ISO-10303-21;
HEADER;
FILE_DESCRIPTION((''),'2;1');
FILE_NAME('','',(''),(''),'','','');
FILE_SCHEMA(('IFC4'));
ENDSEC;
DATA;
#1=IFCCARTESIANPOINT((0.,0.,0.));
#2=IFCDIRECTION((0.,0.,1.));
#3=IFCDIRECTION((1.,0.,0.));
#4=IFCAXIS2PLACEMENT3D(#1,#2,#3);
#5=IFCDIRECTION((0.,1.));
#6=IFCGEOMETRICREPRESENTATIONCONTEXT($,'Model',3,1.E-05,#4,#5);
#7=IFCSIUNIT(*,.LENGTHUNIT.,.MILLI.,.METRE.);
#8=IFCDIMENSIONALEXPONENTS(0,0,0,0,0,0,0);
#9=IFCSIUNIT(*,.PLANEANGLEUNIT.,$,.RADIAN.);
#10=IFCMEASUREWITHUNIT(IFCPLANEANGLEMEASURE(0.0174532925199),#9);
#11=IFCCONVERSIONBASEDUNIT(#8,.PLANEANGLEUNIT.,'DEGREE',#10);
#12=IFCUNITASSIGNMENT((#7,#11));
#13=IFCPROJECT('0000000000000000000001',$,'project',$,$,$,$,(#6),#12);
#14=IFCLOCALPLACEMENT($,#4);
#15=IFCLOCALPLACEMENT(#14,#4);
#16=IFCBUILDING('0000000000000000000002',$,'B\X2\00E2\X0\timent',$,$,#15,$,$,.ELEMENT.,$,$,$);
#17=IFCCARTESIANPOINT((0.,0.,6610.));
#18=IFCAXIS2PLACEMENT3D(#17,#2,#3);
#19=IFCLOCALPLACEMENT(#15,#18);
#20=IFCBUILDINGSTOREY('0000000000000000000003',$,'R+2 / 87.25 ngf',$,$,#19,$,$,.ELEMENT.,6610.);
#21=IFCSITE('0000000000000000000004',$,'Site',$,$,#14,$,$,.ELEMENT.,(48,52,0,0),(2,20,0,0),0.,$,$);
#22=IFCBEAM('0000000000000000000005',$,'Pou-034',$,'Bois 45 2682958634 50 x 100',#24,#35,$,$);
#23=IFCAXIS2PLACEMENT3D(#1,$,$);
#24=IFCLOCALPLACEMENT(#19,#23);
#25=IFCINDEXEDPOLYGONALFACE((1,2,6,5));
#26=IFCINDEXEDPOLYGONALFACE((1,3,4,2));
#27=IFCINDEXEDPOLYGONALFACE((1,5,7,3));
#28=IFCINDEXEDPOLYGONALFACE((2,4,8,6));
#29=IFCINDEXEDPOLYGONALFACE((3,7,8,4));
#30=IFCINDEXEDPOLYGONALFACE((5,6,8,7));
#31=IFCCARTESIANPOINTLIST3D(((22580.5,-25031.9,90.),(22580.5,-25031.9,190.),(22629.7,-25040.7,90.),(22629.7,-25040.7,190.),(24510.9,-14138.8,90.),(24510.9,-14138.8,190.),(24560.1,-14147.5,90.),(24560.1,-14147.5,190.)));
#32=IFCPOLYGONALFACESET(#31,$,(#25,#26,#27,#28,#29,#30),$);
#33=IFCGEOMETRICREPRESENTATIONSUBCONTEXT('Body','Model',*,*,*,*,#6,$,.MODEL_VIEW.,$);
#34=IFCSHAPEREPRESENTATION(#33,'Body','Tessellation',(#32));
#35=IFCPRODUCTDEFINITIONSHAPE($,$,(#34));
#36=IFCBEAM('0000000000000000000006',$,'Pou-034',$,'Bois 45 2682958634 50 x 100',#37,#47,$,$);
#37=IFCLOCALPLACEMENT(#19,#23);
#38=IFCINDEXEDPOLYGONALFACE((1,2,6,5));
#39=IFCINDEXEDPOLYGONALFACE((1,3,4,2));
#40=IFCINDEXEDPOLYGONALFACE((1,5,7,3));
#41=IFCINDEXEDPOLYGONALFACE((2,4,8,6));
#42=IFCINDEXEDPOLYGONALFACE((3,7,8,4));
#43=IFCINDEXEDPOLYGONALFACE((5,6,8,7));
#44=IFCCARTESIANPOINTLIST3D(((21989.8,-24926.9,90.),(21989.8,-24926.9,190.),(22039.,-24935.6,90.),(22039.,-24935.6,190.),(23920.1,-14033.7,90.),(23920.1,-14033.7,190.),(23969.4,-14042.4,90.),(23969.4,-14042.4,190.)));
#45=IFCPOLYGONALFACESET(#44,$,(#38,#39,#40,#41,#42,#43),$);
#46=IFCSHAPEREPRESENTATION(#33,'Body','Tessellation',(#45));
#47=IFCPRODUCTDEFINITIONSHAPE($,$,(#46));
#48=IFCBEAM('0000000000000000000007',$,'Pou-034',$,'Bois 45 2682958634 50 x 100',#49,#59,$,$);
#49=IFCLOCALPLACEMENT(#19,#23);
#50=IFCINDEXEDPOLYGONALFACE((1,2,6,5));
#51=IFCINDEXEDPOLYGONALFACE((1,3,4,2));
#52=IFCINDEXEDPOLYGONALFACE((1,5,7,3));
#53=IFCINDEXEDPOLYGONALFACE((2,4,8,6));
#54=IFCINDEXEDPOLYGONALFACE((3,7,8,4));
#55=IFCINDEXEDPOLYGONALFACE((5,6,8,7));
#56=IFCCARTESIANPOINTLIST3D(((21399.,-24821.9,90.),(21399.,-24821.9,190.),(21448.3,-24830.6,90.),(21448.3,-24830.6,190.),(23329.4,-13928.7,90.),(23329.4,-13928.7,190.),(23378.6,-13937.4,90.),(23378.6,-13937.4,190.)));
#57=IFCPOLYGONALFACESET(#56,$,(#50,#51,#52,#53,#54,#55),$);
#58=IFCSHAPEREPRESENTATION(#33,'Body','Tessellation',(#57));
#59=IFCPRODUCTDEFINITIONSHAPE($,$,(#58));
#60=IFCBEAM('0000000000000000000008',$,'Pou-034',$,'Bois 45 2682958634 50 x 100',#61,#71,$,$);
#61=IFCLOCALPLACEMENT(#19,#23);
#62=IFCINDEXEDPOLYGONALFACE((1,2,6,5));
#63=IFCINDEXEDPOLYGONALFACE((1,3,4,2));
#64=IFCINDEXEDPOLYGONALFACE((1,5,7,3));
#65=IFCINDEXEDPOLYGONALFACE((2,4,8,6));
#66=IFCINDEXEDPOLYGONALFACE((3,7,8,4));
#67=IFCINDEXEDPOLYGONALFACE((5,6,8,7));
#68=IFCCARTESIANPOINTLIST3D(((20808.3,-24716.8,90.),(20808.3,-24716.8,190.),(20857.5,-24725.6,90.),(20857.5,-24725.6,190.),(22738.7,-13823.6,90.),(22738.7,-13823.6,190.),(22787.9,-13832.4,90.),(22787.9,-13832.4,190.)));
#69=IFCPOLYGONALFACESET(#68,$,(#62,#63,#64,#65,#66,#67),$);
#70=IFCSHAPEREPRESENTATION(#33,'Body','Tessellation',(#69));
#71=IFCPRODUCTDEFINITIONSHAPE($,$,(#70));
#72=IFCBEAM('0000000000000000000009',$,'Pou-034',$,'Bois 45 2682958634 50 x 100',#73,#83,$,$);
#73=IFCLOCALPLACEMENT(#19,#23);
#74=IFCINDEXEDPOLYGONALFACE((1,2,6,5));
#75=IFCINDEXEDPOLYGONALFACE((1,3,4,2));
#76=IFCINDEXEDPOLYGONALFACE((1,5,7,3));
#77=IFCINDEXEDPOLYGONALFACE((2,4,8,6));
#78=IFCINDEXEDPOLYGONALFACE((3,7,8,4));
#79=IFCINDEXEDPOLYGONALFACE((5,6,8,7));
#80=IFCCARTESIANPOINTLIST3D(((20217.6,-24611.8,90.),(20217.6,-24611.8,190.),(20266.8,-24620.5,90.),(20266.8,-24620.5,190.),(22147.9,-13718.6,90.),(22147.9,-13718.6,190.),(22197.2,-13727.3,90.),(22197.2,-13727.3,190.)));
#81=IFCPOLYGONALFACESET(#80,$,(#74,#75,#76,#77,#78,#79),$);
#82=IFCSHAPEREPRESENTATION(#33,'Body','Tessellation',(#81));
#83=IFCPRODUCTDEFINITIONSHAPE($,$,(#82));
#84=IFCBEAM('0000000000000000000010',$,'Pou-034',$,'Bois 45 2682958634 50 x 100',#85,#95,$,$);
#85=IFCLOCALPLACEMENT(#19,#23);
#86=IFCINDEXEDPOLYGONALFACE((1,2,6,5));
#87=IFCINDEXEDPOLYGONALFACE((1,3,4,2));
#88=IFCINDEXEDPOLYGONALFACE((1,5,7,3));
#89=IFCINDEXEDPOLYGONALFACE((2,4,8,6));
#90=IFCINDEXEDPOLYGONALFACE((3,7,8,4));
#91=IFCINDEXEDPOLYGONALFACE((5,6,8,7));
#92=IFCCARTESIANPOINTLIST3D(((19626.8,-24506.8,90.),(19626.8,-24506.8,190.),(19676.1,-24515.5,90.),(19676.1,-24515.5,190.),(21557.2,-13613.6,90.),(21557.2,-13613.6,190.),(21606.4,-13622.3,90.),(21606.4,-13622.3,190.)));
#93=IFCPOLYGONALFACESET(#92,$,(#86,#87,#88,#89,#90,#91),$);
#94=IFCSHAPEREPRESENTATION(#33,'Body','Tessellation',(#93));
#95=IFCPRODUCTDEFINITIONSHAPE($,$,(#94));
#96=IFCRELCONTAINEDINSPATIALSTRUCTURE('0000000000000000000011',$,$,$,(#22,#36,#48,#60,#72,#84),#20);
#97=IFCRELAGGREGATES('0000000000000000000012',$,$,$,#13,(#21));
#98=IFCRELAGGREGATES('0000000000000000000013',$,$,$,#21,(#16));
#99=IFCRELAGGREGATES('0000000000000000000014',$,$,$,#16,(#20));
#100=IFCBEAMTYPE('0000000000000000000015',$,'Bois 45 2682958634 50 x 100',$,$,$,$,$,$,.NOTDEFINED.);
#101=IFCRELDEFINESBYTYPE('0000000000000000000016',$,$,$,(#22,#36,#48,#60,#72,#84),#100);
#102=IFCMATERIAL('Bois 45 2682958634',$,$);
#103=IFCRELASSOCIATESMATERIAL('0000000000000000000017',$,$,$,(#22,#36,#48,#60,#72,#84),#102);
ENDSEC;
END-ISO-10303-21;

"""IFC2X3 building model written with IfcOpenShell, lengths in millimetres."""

from ifc_helpers import new_model, entity, si_unit, converted_unit, direction, frame, frame_2d, origin_with_axes, place, context, subcontext, project, spatial, rectangle, extrude, material, type_object, element, save


model = new_model("IFC2X3")

# Units and contexts
model_context = context("Model", 3, precision=1e-05, world=origin_with_axes(), true_north=direction((0.0, 1.0)))
body_context = subcontext(model_context, "Body", "Model", "MODEL_VIEW")
ifc_project = project(units=[si_unit("LENGTHUNIT", "METRE", prefix="MILLI"), converted_unit("PLANEANGLEUNIT", "DEGREE", entity("IfcPlaneAngleMeasure", 0.0174532925199), si_unit("PLANEANGLEUNIT", "RADIAN"), dimensions=[0, 0, 0, 0, 0, 0, 0])], contexts=[model_context])

# Site, building, storey
site_placement = place(None, origin_with_axes())
site = spatial("IfcSite", under=ifc_project, at=site_placement, Name="Site", CompositionType="ELEMENT", RefLatitude=(48, 52, 0, 0), RefLongitude=(2, 20, 0, 0), RefElevation=0.0)
building_placement = place(site_placement, origin_with_axes())
building = spatial("IfcBuilding", under=site, at=building_placement, Name="Bâtiment", CompositionType="ELEMENT")
storey_placement = place(building_placement, frame((0.0, 0.0, 6610.0), z_axis=(0.0, 0.0, 1.0), x_axis=(1.0, 0.0, 0.0)))
storey = spatial("IfcBuildingStorey", under=building, at=storey_placement, Name="R+2 / 87.25 ngf", CompositionType="ELEMENT", Elevation=6610.0)

# Beams
ifc_material_1 = material(Name="Bois 45 2682958634")
beam_type = type_object("IfcBeamType", Name="Bois 45 2682958634 50 x 100", PredefinedType="NOTDEFINED")
for number, where, z_axis, x_axis, name in (
    (1, (22605.1, -25036.3, 190.0), (0.0, 0.0, 1.0), (0.984659, -0.174492, 0.0), "Pou-034"),
    (2, (22014.4, -24931.3, 190.0), (0.0, 0.0, 1.0), (0.984659, -0.174492, 0.0), "Pou-034"),
    (3, (21423.6, -24826.2, 190.0), (0.0, 0.0, 1.0), (0.984659, -0.174492, 0.0), "Pou-034"),
    (4, (20832.9, -24721.2, 190.0), (0.0, 0.0, 1.0), (0.984659, -0.174492, 0.0), "Pou-034"),
    (5, (20242.2, -24616.2, 190.0), (0.0, 0.0, 1.0), (0.984659, -0.174492, 0.0), "Pou-034"),
    (6, (19651.4, -24511.1, 190.0), (0.0, 0.0, 1.0), (0.984659, -0.174492, 0.0), "Pou-034"),
):
    element("IfcBeam", number, at=place(storey_placement, frame(where, z_axis=z_axis, x_axis=x_axis)), inside=storey, type_object=beam_type, material=ifc_material_1, Name=name, ObjectType="Bois 45 2682958634 50 x 100", context=body_context, shape_type="SweptSolid", body=[
        extrude(rectangle(XDim=100.0, YDim=50.0, at=frame_2d((-50.0, 0.0), x_axis=(1.0, 0.0))), frame((0.0, 0.0, 0.0), z_axis=(0.0, 1.0, 0.0), x_axis=(0.0, 0.0, 1.0)), (0.0, 0.0, 1.0), 11062.9),
    ])

save(model, "model.ifc")
